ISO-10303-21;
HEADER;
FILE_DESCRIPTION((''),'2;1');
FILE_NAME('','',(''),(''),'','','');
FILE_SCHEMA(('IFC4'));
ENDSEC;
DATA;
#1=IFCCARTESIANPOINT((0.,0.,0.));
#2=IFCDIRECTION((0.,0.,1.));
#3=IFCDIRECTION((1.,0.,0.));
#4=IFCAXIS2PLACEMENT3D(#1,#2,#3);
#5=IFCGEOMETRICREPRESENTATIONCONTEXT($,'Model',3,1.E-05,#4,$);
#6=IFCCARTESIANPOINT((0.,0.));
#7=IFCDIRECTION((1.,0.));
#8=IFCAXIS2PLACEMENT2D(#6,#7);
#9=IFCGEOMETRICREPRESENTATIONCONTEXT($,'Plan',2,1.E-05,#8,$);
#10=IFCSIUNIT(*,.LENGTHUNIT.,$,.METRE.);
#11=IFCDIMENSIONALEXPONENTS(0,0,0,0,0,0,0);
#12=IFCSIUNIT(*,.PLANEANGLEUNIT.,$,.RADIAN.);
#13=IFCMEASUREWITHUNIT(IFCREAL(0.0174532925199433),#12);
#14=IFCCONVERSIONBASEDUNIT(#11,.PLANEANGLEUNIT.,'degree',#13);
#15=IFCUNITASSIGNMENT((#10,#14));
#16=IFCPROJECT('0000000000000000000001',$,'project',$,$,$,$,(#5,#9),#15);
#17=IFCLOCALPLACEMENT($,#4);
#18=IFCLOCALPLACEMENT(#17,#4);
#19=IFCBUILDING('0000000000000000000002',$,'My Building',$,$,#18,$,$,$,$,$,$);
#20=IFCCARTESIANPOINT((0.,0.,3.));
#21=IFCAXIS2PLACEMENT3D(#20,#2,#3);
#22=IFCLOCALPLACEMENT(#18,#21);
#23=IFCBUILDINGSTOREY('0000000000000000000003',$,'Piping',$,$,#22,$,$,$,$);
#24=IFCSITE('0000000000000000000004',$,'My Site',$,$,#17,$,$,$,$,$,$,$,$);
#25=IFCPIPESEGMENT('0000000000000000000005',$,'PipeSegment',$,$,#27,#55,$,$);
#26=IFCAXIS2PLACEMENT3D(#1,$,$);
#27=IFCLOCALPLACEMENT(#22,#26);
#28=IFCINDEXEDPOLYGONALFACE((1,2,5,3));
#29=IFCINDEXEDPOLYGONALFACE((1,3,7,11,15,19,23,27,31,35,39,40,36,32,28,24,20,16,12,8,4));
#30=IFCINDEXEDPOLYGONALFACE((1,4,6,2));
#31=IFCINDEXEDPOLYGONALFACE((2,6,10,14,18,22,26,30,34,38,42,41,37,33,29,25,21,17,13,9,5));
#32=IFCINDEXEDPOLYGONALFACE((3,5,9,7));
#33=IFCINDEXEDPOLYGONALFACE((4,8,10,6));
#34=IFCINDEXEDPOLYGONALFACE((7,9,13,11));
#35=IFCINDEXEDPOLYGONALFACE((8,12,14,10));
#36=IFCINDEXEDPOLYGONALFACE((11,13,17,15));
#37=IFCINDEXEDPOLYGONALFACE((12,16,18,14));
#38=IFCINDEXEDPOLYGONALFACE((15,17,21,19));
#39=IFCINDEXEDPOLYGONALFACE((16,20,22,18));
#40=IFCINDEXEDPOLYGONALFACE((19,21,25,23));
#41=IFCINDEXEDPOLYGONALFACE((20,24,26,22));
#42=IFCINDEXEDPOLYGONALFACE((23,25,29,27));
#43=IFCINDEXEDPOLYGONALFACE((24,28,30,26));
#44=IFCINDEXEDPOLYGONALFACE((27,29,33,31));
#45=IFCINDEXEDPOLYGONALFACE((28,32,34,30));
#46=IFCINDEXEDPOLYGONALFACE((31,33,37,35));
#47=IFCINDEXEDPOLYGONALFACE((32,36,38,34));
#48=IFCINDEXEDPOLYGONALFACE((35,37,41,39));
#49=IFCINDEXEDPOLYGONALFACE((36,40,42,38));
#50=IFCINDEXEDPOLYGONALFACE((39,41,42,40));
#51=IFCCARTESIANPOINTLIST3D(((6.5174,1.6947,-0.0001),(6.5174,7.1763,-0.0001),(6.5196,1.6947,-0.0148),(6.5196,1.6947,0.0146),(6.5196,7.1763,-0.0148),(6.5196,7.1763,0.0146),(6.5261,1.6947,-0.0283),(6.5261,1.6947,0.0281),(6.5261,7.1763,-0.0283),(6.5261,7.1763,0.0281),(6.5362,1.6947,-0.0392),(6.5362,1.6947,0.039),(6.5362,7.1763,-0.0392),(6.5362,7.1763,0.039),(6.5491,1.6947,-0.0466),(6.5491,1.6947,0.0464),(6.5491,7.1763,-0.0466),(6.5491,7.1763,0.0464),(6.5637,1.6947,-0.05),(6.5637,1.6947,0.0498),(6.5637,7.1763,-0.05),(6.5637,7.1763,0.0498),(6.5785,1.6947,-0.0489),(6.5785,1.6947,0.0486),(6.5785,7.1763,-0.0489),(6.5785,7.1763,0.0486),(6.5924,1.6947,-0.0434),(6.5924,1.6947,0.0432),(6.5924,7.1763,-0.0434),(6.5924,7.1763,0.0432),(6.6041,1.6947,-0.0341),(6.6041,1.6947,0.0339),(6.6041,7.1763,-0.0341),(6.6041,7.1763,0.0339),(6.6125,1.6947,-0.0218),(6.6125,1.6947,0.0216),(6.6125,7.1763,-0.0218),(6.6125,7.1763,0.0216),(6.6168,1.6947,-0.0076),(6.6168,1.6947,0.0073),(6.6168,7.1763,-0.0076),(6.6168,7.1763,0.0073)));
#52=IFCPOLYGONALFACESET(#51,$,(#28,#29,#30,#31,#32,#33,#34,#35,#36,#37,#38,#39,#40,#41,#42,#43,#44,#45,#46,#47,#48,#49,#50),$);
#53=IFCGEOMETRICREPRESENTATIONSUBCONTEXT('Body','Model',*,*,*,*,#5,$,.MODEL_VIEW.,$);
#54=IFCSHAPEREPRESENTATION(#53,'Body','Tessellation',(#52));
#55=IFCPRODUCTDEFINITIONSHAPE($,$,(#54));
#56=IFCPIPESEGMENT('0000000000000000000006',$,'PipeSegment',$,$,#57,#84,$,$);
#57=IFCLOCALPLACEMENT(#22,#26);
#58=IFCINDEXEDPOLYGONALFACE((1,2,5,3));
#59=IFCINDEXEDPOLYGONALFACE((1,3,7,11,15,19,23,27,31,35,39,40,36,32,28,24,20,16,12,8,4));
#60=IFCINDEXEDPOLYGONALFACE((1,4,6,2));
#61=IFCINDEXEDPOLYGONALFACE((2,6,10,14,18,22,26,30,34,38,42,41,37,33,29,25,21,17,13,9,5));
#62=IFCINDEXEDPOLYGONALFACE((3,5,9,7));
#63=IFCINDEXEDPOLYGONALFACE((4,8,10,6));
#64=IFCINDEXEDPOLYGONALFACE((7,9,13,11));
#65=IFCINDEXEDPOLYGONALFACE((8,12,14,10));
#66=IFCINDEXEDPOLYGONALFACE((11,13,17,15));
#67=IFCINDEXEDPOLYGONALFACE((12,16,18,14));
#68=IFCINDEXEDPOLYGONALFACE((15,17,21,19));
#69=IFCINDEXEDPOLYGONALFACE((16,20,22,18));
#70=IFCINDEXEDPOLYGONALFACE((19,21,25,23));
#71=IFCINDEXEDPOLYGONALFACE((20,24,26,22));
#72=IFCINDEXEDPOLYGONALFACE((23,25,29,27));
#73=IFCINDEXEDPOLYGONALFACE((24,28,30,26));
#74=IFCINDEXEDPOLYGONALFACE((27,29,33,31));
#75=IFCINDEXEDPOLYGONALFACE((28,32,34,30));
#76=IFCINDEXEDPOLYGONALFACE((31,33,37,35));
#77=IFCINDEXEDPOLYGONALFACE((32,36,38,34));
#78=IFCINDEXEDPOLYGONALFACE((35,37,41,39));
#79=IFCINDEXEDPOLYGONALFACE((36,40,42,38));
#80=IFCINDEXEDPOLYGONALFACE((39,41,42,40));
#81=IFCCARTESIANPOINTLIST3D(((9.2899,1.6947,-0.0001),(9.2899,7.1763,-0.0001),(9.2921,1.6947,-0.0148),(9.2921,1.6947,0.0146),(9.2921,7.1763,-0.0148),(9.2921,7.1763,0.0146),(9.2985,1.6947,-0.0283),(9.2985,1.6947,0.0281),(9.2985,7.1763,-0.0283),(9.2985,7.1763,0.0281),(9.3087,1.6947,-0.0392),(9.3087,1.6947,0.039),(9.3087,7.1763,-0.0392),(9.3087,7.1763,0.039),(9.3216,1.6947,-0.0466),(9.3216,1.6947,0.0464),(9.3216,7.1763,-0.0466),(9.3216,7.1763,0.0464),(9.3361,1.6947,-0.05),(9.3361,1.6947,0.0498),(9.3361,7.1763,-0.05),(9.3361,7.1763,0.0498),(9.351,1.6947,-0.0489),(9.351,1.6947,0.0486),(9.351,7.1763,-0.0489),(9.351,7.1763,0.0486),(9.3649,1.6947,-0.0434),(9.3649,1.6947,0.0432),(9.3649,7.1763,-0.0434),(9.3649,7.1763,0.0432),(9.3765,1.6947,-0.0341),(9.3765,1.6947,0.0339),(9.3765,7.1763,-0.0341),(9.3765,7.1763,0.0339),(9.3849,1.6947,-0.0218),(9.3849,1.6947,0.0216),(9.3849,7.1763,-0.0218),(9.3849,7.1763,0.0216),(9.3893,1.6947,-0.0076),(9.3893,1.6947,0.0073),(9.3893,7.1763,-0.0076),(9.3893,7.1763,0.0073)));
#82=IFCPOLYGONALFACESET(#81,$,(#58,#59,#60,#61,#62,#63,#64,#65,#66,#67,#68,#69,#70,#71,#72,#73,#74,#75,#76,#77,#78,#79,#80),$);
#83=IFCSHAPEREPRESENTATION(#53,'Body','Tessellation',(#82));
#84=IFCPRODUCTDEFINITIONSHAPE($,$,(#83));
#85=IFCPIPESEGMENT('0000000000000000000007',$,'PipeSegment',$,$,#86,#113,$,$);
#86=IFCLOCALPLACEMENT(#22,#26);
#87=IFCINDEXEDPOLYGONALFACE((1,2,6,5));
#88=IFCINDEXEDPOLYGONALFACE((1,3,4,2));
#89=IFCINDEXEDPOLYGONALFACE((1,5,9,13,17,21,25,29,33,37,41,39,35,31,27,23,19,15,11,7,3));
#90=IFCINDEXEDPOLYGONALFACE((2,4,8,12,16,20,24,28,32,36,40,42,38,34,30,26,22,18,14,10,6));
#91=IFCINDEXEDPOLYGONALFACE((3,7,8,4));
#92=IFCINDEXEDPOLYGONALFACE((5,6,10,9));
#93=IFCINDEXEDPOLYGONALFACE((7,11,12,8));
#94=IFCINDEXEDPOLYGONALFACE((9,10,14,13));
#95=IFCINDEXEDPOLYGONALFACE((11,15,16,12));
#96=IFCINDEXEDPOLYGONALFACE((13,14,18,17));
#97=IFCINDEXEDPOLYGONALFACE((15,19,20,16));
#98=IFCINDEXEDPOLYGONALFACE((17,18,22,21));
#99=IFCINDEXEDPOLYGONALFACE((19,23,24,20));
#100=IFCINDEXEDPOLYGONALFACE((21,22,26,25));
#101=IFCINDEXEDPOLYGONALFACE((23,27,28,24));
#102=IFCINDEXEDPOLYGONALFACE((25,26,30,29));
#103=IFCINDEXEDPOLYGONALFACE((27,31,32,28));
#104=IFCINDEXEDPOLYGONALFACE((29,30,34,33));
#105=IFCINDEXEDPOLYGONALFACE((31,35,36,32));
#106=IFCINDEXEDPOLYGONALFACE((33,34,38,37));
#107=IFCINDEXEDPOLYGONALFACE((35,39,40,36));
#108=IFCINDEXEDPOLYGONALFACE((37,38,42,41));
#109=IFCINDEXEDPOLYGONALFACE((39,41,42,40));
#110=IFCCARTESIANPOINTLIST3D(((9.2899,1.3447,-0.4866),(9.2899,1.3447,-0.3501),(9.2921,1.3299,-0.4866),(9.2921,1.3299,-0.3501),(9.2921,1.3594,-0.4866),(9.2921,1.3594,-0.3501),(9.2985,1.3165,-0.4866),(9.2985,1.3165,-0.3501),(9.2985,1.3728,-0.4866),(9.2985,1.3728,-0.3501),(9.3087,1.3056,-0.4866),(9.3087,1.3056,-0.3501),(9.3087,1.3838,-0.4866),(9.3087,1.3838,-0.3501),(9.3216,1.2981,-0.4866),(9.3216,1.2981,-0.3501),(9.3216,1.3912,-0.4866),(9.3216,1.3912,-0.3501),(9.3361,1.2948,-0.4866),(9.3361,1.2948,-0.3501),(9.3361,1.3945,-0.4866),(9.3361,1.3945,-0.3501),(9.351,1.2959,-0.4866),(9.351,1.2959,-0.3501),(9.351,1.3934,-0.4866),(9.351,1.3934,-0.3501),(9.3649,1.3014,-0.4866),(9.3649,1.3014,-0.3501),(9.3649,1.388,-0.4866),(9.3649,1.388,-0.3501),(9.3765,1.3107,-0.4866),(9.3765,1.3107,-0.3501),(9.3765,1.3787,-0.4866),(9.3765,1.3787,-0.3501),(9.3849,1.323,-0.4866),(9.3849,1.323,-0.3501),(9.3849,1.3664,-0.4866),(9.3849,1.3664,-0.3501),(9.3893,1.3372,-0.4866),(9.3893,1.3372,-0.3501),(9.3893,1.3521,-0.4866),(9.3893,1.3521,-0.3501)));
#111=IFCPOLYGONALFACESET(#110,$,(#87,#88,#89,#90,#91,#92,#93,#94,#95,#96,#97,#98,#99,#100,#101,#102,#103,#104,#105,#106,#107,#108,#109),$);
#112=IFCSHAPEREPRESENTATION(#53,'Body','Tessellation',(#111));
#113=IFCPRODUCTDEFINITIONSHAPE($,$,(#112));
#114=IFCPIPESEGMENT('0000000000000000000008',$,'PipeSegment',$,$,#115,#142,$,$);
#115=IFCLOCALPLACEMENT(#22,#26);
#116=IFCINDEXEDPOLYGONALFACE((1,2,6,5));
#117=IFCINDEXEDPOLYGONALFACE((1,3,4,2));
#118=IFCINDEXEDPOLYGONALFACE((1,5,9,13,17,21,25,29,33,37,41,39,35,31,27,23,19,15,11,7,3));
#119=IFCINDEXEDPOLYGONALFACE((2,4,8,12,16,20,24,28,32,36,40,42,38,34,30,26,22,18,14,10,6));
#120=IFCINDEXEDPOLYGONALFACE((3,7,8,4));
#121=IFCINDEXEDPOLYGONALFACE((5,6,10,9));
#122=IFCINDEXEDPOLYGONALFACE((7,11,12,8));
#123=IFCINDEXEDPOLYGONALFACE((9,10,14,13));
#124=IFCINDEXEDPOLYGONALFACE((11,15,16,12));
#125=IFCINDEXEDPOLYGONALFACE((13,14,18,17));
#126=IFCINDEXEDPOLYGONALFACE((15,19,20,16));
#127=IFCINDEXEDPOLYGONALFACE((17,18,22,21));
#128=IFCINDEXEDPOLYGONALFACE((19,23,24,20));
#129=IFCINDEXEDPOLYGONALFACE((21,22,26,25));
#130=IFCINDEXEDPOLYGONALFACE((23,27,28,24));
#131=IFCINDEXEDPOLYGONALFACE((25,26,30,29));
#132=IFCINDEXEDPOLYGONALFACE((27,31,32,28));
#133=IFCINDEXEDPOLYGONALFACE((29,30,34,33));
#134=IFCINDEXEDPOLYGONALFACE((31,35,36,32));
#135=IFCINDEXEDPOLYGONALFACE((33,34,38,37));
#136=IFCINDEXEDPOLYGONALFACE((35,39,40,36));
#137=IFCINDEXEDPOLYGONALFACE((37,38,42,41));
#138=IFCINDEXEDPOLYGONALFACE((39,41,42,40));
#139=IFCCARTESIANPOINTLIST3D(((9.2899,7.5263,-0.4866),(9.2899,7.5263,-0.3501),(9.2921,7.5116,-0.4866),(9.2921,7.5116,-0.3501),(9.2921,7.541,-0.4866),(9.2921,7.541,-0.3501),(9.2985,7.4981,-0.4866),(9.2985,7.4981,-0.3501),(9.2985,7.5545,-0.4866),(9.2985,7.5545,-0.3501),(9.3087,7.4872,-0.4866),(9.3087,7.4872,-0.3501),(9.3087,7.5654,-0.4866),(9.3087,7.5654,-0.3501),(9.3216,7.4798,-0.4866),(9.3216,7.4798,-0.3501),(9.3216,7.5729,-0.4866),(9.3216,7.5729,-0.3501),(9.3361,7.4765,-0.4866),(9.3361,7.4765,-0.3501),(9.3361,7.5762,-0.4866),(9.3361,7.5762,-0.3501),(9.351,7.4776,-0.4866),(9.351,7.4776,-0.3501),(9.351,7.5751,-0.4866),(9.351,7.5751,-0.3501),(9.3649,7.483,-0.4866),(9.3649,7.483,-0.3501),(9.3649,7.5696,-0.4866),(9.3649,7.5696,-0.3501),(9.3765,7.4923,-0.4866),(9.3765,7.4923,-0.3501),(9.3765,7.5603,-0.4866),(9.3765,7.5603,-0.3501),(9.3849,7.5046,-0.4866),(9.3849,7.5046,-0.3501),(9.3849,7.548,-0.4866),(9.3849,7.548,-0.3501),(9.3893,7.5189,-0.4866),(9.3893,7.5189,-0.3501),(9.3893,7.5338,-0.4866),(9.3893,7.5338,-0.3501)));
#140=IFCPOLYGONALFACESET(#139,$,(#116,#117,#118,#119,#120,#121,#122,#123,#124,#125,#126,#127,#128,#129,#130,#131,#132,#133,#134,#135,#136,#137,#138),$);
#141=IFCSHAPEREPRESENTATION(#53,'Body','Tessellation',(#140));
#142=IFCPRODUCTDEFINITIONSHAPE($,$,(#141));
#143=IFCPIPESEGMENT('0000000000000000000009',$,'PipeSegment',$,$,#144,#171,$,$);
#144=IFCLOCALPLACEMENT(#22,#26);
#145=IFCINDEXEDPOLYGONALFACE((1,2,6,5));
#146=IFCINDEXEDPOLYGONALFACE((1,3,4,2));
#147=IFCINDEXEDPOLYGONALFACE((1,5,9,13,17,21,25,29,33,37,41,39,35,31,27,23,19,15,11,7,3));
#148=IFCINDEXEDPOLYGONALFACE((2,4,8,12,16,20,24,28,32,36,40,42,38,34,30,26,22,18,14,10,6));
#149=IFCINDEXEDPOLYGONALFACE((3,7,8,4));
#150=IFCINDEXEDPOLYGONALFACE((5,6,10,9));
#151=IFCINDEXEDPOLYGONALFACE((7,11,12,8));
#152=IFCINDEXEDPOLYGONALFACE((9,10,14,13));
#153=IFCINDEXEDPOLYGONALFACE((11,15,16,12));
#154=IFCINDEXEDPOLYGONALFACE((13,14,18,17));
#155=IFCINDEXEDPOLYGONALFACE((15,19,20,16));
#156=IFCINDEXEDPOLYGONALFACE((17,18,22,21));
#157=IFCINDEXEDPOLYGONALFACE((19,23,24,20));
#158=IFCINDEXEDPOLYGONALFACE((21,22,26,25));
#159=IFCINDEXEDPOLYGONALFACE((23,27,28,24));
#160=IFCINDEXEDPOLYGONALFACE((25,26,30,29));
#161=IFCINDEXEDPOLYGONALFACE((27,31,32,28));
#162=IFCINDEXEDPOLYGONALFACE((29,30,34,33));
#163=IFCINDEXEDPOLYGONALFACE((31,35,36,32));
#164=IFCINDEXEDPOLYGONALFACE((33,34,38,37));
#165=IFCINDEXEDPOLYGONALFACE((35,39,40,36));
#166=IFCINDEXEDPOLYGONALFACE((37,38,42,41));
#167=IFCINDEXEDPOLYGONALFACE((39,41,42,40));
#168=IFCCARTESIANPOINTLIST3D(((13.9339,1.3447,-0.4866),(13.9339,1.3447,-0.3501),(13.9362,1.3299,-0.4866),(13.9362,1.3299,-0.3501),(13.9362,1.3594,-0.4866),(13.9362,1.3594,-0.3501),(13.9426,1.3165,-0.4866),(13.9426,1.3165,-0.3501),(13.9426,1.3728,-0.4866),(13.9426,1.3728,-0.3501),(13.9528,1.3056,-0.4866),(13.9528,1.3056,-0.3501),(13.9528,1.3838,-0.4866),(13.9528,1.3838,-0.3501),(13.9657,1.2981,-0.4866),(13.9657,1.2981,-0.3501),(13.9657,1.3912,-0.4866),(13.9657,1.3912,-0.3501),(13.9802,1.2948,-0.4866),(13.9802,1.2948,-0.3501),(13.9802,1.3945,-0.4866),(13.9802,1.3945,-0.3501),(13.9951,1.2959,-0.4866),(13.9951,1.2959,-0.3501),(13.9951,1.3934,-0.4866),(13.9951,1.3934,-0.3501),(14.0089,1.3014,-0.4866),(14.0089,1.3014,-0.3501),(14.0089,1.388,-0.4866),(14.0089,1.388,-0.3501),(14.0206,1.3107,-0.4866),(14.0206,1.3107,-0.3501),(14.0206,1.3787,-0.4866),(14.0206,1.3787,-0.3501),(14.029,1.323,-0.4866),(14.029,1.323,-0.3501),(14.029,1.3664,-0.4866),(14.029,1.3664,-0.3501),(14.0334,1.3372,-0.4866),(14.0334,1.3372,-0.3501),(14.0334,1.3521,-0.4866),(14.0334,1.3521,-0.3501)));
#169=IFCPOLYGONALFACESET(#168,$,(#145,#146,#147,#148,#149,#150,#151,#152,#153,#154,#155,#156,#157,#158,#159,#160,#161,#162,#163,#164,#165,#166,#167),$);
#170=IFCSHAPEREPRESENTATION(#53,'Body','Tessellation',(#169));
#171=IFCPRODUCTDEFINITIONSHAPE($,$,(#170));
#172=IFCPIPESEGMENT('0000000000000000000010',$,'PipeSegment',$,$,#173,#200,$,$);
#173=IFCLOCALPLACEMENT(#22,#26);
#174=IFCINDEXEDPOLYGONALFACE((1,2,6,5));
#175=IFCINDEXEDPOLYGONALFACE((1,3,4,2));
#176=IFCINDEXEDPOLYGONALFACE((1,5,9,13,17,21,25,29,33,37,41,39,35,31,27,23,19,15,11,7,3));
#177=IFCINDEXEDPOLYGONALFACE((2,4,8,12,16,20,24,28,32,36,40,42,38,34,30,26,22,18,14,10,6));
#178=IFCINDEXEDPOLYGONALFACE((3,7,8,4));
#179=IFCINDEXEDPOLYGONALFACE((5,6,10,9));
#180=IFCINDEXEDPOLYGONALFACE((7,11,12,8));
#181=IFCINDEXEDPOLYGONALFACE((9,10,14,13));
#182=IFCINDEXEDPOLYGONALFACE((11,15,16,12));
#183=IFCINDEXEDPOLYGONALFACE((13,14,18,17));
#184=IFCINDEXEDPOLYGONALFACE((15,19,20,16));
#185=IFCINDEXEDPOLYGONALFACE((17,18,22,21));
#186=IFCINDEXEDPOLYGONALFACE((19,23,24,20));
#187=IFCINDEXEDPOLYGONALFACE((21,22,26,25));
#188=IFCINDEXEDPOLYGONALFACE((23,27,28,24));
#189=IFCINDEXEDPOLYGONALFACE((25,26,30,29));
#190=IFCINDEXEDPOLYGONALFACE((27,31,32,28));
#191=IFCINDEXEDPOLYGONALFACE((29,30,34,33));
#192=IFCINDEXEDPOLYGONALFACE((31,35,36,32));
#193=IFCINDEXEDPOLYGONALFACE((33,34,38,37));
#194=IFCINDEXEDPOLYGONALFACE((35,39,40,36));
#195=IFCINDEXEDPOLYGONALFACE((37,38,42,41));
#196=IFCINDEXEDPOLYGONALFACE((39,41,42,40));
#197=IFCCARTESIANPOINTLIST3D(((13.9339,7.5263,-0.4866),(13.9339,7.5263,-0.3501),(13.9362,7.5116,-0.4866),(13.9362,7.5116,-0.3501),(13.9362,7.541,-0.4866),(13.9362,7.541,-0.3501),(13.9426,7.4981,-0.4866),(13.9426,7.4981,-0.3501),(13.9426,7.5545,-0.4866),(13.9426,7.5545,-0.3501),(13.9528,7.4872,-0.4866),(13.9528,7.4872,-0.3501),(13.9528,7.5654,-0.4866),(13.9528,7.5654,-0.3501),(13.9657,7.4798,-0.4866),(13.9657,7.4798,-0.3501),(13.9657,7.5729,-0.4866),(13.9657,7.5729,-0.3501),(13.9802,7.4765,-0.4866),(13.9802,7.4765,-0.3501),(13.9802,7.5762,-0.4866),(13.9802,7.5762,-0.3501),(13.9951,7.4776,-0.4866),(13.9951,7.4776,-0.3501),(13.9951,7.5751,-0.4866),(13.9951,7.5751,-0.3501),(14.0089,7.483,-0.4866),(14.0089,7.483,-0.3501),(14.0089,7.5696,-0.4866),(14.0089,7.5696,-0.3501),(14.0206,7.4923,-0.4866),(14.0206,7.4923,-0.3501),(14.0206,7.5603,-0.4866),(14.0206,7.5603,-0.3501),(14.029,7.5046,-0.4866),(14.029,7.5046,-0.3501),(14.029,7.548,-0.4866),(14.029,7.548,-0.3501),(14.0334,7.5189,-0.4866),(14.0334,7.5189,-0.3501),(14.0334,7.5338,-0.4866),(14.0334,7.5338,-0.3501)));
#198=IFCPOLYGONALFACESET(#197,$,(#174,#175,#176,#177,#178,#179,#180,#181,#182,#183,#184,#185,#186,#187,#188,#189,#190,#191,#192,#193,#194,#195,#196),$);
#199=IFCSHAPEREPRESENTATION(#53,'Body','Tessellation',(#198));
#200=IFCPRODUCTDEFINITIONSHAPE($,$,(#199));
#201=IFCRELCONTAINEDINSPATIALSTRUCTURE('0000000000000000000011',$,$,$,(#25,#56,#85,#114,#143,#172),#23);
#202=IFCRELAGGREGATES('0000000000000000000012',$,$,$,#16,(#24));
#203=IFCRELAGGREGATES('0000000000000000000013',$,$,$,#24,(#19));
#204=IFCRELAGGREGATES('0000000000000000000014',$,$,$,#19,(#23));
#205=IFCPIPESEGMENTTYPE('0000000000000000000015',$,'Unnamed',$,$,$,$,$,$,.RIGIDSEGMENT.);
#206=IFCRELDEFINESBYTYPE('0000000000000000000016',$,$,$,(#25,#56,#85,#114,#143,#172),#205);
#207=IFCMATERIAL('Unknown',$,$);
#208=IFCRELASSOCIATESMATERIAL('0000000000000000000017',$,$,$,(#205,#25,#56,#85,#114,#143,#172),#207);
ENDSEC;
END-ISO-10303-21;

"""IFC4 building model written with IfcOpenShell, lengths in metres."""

from ifc_helpers import new_model, entity, si_unit, converted_unit, frame, origin_with_axes, origin_2d_with_axis, place, context, subcontext, project, spatial, circle, extrude, material, material_profile, profile_set, profile_usage, type_object, element, save


model = new_model("IFC4")

# Units and contexts
model_context = context("Model", 3, precision=1e-05, world=origin_with_axes())
plan_context = context("Plan", 2, precision=1e-05, world=origin_2d_with_axis())
body_context = subcontext(model_context, "Body", "Model", "MODEL_VIEW")
ifc_project = project(units=[si_unit("LENGTHUNIT", "METRE"), converted_unit("PLANEANGLEUNIT", "degree", entity("IfcReal", 0.0174532925199433), si_unit("PLANEANGLEUNIT", "RADIAN"), dimensions=[0, 0, 0, 0, 0, 0, 0])], contexts=[model_context, plan_context])

# Site, building, storey
site_placement = place(None, origin_with_axes())
site = spatial("IfcSite", under=ifc_project, at=site_placement, Name="My Site")
building_placement = place(site_placement, origin_with_axes())
building = spatial("IfcBuilding", under=site, at=building_placement, Name="My Building")
storey_placement = place(building_placement, frame((0.0, 0.0, 3.0), z_axis=(0.0, 0.0, 1.0), x_axis=(1.0, 0.0, 0.0)))
storey = spatial("IfcBuildingStorey", under=building, at=storey_placement, Name="Piping")

# Pipe segments
ifc_material = material(Name="Unknown")
ifc_material_profile = material_profile(ifc_material, circle(Radius=0.05))
ifc_profile_set = profile_set([ifc_material_profile])
pipe_segment_type = type_object("IfcPipeSegmentType", Name="Unnamed", PredefinedType="RIGIDSEGMENT", material=ifc_profile_set)
ifc_profile_usage_1 = profile_usage(ifc_profile_set, cardinal=5)
pipe_segment_1_placement = place(storey_placement, frame((6.5674, 1.6947, -0.0001), z_axis=(0.0, 1.0, 0.0), x_axis=(-1.0, 0.0, 0.0)))
element("IfcPipeSegment", 1, at=pipe_segment_1_placement, inside=storey, type_object=pipe_segment_type, material=ifc_profile_usage_1, Name="PipeSegment", context=body_context, shape_type="SweptSolid", body=[
    extrude(circle(Radius=0.05), origin_with_axes(), (0.0, 0.0, 1.0), 5.4816),
])
ifc_profile_usage_2 = profile_usage(ifc_profile_set, cardinal=5)
pipe_segment_2_placement = place(storey_placement, frame((9.3399, 1.6947, -0.0001), z_axis=(0.0, 1.0, 0.0), x_axis=(-1.0, 0.0, 0.0)))
element("IfcPipeSegment", 2, at=pipe_segment_2_placement, inside=storey, type_object=pipe_segment_type, material=ifc_profile_usage_2, Name="PipeSegment", context=body_context, shape_type="SweptSolid", body=[
    extrude(circle(Radius=0.05), origin_with_axes(), (0.0, 0.0, 1.0), 5.4816),
])
ifc_profile_usage_3 = profile_usage(ifc_profile_set, cardinal=5)
pipe_segment_3_placement = place(storey_placement, frame((9.3399, 1.3447, -0.3501), z_axis=(0.0, 0.0, -1.0), x_axis=(-1.0, 0.0, 0.0)))
element("IfcPipeSegment", 3, at=pipe_segment_3_placement, inside=storey, type_object=pipe_segment_type, material=ifc_profile_usage_3, Name="PipeSegment", context=body_context, shape_type="SweptSolid", body=[
    extrude(circle(Radius=0.05), origin_with_axes(), (0.0, 0.0, 1.0), 0.1365),
])
ifc_profile_usage_4 = profile_usage(ifc_profile_set, cardinal=5)
pipe_segment_4_placement = place(storey_placement, frame((9.3399, 7.5263, -0.3501), z_axis=(0.0, 0.0, -1.0), x_axis=(-1.0, 0.0, 0.0)))
element("IfcPipeSegment", 4, at=pipe_segment_4_placement, inside=storey, type_object=pipe_segment_type, material=ifc_profile_usage_4, Name="PipeSegment", context=body_context, shape_type="SweptSolid", body=[
    extrude(circle(Radius=0.05), origin_with_axes(), (0.0, 0.0, 1.0), 0.1365),
])
ifc_profile_usage_5 = profile_usage(ifc_profile_set, cardinal=5)
pipe_segment_5_placement = place(storey_placement, frame((13.9839, 1.3447, -0.3501), z_axis=(0.0, 0.0, -1.0), x_axis=(-1.0, 0.0, 0.0)))
element("IfcPipeSegment", 5, at=pipe_segment_5_placement, inside=storey, type_object=pipe_segment_type, material=ifc_profile_usage_5, Name="PipeSegment", context=body_context, shape_type="SweptSolid", body=[
    extrude(circle(Radius=0.05), origin_with_axes(), (0.0, 0.0, 1.0), 0.1365),
])
ifc_profile_usage_6 = profile_usage(ifc_profile_set, cardinal=5)
pipe_segment_6_placement = place(storey_placement, frame((13.9839, 7.5263, -0.3501), z_axis=(0.0, 0.0, -1.0), x_axis=(-1.0, 0.0, 0.0)))
element("IfcPipeSegment", 6, at=pipe_segment_6_placement, inside=storey, type_object=pipe_segment_type, material=ifc_profile_usage_6, Name="PipeSegment", context=body_context, shape_type="SweptSolid", body=[
    extrude(circle(Radius=0.05), origin_with_axes(), (0.0, 0.0, 1.0), 0.1365),
])

save(model, "model.ifc")
